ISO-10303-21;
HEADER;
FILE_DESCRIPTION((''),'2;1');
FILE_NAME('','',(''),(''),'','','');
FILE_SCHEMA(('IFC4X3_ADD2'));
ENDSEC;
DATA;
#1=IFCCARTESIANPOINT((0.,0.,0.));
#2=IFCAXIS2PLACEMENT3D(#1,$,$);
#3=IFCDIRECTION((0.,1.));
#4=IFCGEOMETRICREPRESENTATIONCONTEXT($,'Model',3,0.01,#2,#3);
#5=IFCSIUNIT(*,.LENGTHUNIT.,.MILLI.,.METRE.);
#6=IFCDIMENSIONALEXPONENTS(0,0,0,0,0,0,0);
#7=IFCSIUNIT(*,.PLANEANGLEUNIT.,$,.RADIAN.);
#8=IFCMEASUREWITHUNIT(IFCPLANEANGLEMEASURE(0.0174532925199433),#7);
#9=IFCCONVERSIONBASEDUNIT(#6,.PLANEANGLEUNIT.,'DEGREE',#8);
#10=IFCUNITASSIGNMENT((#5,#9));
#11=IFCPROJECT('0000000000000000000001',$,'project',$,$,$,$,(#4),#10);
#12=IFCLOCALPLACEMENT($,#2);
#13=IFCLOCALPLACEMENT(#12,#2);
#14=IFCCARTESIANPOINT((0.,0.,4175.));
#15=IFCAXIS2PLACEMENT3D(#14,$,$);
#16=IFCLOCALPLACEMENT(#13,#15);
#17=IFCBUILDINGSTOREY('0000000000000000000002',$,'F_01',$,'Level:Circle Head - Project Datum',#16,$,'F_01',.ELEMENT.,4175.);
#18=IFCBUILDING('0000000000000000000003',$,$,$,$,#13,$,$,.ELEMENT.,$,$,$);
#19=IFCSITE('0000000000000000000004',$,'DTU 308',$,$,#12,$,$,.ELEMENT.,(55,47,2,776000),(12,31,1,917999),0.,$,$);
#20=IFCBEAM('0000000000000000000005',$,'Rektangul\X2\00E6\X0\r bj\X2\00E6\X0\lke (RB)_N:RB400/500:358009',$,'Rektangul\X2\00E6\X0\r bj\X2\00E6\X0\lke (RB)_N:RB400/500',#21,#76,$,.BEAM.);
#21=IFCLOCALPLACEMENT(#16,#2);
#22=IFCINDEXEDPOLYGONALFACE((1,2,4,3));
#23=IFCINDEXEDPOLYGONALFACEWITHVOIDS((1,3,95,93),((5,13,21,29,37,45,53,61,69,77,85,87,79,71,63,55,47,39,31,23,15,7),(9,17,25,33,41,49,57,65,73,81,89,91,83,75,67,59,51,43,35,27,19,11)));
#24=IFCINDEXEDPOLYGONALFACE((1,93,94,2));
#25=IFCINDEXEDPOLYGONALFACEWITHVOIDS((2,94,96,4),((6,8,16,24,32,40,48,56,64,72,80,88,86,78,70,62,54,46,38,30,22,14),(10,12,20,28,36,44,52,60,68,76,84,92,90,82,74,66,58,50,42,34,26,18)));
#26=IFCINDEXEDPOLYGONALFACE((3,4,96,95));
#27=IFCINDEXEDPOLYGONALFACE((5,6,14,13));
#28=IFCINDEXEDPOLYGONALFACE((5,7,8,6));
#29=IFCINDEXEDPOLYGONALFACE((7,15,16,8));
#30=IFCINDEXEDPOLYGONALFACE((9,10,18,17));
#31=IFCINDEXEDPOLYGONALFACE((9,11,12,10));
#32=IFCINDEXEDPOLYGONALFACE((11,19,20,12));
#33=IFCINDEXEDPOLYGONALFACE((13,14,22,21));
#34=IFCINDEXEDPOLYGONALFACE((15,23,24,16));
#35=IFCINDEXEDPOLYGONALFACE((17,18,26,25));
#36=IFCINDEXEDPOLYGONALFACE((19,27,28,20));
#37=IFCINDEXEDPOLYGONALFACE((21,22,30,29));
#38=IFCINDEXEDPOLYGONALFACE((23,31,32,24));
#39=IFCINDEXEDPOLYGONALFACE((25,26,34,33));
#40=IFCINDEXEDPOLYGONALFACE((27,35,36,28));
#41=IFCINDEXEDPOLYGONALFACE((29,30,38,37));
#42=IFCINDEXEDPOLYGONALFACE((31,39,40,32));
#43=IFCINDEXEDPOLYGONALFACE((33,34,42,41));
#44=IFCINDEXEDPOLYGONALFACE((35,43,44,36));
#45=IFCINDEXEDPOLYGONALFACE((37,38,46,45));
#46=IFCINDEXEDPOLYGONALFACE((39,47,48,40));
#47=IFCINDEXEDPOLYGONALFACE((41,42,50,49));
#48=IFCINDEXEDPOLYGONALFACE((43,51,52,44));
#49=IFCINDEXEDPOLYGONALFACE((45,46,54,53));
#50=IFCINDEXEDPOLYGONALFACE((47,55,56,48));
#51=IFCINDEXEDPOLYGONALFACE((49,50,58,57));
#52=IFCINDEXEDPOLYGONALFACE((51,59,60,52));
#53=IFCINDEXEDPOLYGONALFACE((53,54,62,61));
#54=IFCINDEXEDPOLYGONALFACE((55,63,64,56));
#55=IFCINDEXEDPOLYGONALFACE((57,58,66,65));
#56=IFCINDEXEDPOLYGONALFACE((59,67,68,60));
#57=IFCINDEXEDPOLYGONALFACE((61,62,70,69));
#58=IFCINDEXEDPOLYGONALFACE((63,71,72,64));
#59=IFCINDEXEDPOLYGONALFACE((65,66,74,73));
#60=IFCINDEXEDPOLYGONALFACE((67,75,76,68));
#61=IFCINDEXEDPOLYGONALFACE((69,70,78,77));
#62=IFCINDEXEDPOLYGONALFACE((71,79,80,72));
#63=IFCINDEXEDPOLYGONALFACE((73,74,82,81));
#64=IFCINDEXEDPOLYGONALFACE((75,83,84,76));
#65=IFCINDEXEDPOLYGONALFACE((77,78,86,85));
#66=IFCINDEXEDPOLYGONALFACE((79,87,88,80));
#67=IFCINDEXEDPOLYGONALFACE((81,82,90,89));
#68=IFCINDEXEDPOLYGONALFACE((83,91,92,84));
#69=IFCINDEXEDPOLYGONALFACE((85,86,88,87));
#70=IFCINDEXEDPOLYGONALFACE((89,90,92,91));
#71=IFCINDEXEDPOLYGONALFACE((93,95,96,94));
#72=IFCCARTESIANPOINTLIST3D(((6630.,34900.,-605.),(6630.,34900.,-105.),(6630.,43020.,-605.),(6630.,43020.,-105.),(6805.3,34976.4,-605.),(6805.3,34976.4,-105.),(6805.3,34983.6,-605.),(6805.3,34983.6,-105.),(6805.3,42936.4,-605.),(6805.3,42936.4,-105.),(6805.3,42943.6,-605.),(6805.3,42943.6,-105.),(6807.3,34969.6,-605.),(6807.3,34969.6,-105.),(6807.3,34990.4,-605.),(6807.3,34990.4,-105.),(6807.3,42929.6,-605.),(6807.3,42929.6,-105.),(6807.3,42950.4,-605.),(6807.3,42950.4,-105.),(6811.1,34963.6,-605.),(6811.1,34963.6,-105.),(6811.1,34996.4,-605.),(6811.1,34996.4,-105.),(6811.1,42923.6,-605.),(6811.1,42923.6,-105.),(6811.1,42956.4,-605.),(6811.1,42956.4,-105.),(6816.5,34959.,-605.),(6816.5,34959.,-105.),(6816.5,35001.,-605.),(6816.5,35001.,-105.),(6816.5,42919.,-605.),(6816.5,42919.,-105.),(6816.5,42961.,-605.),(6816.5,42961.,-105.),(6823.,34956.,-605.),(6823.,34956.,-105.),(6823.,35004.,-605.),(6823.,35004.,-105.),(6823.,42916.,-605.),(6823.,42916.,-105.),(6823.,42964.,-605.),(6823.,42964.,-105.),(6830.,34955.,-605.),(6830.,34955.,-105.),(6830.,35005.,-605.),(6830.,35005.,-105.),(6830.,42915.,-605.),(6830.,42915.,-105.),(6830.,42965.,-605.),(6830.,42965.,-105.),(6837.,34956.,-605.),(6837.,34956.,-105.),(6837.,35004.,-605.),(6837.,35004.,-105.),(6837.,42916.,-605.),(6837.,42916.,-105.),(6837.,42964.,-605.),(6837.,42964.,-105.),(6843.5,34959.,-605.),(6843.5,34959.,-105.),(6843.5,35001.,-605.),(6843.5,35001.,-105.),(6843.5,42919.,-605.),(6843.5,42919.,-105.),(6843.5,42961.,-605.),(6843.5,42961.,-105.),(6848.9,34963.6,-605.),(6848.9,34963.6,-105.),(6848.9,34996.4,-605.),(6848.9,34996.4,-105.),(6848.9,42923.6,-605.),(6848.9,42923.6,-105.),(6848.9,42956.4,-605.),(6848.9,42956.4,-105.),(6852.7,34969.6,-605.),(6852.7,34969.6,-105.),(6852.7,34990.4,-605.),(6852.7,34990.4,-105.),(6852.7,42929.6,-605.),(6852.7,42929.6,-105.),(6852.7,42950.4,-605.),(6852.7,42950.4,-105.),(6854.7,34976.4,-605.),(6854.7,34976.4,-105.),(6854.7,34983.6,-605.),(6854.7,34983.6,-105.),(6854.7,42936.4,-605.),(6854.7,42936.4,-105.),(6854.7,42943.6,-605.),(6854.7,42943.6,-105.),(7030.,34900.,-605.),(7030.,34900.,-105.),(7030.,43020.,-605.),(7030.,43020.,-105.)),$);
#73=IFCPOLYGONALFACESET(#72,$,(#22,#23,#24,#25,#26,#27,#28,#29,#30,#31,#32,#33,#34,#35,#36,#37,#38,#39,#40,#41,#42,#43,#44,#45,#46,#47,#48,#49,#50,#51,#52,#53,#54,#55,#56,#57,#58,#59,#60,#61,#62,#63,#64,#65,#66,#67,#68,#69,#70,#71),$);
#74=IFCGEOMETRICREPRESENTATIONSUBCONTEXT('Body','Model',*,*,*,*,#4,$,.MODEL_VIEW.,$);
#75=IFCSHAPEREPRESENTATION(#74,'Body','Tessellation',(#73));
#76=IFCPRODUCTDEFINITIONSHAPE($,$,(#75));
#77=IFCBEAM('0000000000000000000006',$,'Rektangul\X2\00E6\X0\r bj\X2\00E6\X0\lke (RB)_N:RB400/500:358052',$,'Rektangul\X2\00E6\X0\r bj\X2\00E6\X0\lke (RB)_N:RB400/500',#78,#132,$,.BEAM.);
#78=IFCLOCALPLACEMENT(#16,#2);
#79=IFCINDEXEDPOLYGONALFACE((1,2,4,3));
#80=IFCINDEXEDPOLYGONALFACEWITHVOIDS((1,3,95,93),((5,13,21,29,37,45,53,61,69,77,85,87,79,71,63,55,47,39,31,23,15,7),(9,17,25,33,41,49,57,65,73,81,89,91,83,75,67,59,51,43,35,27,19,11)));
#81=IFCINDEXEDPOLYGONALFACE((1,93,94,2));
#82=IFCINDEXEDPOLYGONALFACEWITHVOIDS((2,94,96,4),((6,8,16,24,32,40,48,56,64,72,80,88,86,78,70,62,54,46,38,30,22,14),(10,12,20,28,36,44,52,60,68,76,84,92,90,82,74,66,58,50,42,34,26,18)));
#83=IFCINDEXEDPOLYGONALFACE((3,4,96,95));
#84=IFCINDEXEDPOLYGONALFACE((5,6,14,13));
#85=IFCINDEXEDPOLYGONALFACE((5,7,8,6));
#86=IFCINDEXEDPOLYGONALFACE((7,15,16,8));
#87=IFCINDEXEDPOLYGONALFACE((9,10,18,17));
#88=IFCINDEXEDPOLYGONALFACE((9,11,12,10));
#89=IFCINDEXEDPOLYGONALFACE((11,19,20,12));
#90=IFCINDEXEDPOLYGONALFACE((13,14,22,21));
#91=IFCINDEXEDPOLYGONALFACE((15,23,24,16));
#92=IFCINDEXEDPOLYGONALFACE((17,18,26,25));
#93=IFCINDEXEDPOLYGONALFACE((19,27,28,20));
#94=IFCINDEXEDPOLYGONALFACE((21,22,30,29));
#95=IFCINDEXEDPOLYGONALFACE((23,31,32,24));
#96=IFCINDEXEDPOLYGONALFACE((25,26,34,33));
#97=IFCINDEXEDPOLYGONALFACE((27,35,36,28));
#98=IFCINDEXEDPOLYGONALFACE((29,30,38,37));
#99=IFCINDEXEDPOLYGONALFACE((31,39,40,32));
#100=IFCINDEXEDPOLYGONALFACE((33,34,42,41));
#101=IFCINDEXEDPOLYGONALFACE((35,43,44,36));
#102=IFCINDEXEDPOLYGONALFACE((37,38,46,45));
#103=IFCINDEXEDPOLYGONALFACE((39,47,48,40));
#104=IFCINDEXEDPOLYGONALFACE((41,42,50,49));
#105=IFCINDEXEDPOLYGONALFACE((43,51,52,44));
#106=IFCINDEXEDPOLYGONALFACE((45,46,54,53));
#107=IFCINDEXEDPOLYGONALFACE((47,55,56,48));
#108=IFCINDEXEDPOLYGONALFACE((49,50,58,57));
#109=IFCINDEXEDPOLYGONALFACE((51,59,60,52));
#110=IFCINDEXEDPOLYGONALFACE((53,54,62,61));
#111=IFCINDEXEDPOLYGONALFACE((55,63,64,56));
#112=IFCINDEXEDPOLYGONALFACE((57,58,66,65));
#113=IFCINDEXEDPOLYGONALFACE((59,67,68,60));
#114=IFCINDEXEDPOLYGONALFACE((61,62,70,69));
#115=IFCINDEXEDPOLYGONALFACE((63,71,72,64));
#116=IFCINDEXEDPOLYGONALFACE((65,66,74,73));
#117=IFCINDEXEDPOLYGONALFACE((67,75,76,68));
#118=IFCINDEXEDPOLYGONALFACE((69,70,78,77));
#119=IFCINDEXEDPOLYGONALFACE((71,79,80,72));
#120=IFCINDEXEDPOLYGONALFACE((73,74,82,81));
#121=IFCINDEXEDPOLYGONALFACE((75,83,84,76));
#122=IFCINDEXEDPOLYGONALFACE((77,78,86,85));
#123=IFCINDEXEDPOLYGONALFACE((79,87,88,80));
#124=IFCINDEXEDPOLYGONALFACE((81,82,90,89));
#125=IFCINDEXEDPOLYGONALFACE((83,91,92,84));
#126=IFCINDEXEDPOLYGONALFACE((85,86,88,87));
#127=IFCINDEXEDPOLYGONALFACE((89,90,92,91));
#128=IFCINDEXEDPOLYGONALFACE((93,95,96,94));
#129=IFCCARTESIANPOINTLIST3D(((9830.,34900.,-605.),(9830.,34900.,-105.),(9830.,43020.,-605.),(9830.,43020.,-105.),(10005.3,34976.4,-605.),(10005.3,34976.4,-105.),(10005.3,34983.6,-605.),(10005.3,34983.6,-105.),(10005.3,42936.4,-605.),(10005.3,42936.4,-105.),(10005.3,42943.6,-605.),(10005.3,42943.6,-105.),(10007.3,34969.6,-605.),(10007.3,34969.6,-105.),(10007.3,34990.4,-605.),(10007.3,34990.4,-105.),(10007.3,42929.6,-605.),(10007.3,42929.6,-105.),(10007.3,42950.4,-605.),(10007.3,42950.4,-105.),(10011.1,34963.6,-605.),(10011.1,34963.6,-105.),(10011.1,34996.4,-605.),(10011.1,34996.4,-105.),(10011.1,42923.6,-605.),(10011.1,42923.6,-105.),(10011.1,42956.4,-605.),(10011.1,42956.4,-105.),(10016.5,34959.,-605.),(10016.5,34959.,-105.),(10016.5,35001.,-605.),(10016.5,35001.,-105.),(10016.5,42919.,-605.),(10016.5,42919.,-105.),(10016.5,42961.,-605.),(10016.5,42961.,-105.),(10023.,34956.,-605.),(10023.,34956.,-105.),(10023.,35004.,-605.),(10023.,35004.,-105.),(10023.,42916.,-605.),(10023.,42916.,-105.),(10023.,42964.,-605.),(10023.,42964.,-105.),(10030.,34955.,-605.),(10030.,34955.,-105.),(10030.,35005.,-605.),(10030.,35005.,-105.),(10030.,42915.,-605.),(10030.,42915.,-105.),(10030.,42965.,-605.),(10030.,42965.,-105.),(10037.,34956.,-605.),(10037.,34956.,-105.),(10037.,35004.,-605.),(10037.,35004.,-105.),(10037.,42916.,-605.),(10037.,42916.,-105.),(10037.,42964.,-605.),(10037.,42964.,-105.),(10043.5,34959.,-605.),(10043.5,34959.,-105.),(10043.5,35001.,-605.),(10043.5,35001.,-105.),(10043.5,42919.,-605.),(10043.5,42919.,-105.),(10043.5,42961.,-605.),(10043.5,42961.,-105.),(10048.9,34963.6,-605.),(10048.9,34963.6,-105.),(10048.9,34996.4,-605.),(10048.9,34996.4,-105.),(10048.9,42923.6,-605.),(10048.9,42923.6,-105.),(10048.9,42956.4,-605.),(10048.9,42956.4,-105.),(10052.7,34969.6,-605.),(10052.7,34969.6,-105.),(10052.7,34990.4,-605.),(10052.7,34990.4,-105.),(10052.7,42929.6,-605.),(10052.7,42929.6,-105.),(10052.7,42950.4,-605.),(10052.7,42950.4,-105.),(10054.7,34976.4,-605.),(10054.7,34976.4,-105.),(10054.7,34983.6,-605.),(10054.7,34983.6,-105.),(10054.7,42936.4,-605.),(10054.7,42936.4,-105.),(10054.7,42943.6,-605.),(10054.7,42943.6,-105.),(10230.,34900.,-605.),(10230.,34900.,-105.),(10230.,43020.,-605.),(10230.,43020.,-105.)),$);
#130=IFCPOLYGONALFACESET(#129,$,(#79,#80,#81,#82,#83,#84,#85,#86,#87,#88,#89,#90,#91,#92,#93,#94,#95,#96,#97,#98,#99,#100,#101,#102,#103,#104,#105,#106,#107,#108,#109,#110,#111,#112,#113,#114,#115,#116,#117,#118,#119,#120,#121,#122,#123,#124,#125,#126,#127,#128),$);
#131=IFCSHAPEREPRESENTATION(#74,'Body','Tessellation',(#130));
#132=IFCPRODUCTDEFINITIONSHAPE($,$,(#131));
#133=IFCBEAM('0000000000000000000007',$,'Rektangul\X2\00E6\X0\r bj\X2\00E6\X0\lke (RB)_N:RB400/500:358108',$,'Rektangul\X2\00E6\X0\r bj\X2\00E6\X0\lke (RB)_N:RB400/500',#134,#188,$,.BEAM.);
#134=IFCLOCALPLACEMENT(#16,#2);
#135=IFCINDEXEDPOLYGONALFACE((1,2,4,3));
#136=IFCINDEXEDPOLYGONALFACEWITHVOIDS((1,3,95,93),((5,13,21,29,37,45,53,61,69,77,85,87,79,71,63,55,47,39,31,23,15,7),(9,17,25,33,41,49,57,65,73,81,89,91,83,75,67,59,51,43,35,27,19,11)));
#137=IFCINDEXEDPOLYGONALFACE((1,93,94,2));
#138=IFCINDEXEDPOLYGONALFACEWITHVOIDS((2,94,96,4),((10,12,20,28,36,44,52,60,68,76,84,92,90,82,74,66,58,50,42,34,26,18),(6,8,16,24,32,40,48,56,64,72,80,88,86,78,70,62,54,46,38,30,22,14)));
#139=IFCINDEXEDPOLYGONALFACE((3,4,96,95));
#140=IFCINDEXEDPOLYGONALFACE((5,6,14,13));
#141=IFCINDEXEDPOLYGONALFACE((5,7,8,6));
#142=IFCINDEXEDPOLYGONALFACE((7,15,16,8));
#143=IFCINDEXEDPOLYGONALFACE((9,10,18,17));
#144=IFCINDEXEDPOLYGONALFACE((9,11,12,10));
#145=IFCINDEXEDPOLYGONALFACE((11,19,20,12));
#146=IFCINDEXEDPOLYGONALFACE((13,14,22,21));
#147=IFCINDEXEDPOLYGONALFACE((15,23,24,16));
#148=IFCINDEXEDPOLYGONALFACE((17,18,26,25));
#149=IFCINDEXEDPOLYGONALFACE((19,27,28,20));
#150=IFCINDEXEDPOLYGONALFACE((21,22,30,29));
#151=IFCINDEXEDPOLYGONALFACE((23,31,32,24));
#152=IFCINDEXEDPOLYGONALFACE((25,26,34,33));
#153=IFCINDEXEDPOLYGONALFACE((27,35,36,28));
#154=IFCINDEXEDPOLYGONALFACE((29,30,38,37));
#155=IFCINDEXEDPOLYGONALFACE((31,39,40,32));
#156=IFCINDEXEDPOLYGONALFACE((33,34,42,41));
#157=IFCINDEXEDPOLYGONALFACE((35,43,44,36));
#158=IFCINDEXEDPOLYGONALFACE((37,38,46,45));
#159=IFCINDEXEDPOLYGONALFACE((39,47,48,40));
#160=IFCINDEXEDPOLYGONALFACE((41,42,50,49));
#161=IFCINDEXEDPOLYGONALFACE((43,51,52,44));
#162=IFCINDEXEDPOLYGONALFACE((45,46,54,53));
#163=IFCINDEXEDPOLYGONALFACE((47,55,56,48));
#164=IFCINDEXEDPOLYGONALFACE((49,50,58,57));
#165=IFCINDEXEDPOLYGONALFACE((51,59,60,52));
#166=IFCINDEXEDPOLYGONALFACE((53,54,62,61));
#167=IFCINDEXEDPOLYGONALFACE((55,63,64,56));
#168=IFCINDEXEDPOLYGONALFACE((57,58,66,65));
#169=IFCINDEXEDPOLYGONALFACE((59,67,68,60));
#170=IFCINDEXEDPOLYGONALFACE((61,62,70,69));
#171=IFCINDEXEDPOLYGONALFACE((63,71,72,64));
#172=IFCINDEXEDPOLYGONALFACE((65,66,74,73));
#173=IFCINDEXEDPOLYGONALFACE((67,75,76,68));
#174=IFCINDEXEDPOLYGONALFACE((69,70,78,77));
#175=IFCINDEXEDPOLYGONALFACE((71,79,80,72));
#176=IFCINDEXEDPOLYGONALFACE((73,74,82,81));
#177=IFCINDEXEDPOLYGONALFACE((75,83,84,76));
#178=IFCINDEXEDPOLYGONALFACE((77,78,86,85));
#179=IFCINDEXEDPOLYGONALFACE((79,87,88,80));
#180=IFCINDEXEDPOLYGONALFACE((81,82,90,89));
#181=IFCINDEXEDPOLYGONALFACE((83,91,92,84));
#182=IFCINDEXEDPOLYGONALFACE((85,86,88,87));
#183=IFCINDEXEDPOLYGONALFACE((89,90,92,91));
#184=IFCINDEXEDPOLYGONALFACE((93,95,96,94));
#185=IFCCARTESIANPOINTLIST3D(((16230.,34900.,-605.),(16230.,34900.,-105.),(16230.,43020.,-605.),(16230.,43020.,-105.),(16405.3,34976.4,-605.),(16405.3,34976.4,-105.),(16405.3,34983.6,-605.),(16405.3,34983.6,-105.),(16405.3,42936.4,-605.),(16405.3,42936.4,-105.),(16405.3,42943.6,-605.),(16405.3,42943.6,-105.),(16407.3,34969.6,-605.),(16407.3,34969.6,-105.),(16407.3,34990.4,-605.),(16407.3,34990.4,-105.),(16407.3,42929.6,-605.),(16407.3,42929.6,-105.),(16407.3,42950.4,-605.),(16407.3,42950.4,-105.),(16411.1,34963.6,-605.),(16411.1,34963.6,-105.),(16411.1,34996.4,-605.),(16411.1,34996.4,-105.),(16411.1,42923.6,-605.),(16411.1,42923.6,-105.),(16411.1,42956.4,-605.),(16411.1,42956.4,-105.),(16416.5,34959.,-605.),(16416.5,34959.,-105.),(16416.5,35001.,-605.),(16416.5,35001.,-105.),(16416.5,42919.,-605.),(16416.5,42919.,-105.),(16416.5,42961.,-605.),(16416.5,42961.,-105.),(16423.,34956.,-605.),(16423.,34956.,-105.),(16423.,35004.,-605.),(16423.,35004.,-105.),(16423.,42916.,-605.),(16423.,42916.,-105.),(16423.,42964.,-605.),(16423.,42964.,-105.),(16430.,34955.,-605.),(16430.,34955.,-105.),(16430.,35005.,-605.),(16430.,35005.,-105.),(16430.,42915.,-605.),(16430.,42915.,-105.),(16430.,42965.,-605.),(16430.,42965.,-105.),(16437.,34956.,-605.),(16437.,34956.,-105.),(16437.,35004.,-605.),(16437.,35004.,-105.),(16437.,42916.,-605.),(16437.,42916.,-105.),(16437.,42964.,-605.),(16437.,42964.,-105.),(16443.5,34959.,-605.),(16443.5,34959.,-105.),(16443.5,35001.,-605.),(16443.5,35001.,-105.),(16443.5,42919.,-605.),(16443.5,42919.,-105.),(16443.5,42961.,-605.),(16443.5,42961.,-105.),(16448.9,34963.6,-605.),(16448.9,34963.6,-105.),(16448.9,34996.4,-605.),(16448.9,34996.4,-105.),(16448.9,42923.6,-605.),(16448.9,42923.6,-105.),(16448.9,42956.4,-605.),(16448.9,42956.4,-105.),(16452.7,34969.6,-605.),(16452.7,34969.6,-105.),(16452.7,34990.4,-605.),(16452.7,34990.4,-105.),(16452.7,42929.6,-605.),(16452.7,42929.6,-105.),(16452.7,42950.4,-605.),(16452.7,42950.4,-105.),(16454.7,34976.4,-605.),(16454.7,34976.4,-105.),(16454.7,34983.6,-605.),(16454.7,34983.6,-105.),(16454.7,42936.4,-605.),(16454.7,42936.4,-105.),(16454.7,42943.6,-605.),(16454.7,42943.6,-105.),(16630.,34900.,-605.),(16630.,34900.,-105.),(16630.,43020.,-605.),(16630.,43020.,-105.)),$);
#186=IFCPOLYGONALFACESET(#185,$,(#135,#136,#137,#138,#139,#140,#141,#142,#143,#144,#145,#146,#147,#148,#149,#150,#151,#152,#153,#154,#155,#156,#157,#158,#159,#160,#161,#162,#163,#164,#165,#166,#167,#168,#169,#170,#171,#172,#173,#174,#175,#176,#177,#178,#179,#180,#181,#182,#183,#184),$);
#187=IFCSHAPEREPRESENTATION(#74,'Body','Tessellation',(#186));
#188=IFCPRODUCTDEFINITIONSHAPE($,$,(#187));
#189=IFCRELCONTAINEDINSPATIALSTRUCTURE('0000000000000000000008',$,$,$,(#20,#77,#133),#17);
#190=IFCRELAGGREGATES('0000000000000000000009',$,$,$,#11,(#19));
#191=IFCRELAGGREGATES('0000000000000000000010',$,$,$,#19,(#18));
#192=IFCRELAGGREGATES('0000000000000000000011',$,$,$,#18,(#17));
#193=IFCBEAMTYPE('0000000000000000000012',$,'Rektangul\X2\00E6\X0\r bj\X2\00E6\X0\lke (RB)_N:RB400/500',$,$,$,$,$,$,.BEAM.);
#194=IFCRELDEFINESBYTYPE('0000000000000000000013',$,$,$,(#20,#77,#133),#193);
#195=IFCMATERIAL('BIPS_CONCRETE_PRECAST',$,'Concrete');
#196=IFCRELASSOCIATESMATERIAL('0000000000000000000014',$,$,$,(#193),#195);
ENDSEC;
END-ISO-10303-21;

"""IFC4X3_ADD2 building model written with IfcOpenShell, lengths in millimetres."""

from ifc_helpers import new_model, entity, si_unit, converted_unit, direction, frame, frame_2d, origin, place, context, subcontext, project, spatial, polyline, circle_curve, parameter, trimmed, segment, composite_curve, outline, extrude, source, transform, mapped, material, material_profile, profile_set, type_object, element, save


model = new_model("IFC4X3_ADD2")

# Units and contexts
model_context = context("Model", 3, precision=0.01, world=origin(), true_north=direction((0.0, 1.0)))
body_context = subcontext(model_context, "Body", "Model", "MODEL_VIEW")
ifc_project = project(units=[si_unit("LENGTHUNIT", "METRE", prefix="MILLI"), converted_unit("PLANEANGLEUNIT", "DEGREE", entity("IfcPlaneAngleMeasure", 0.0174532925199433), si_unit("PLANEANGLEUNIT", "RADIAN"), dimensions=[0, 0, 0, 0, 0, 0, 0])], contexts=[model_context])

# Site, building, storey
site_placement = place(None, origin())
site = spatial("IfcSite", under=ifc_project, at=site_placement, Name="DTU 308", CompositionType="ELEMENT", RefLatitude=(55, 47, 2, 776000), RefLongitude=(12, 31, 1, 917999), RefElevation=0.0)
building_placement = place(site_placement, origin())
building = spatial("IfcBuilding", under=site, at=building_placement, CompositionType="ELEMENT")
storey_placement = place(building_placement, frame((0.0, 0.0, 4175.0)))
storey = spatial("IfcBuildingStorey", under=building, at=storey_placement, Name="F_01", ObjectType="Level:Circle Head - Project Datum", LongName="F_01", CompositionType="ELEMENT", Elevation=4175.0)

# Beams
ifc_material_1 = material(Name="BIPS_CONCRETE_PRECAST", Category="Concrete")
ifc_material_profile_1 = material_profile(ifc_material_1, outline(polyline([(-4060.0, -200.0), (4060.0, -200.0), (4060.0, 200.0), (-4060.0, 200.0), (-4060.0, -200.0)]), holes=[composite_curve([segment(trimmed(circle_curve(frame_2d((3980.0, 0.0), x_axis=(-1.0, 0.0)), 25.0), [parameter(0.0)], [parameter(180.0)], True, "PARAMETER"), False, "CONTINUOUS"), segment(trimmed(circle_curve(frame_2d((3980.0, 0.0), x_axis=(-1.0, 0.0)), 25.0), [parameter(180.0)], [parameter(360.0)], True, "PARAMETER"), False, "CONTINUOUS")], self_intersect=False), composite_curve([segment(trimmed(circle_curve(frame_2d((-3980.0, 0.0), x_axis=(-1.0, 0.0)), 25.0), [parameter(0.0)], [parameter(180.0)], True, "PARAMETER"), False, "CONTINUOUS"), segment(trimmed(circle_curve(frame_2d((-3980.0, 0.0), x_axis=(-1.0, 0.0)), 25.0), [parameter(180.0)], [parameter(360.0)], True, "PARAMETER"), False, "CONTINUOUS")], self_intersect=False)]), Name="RB400/500")
ifc_profile_set_1 = profile_set([ifc_material_profile_1], Name="RB400/500")
beam_type_1 = type_object("IfcBeamType", Name="Rektangulær bjælke (RB)_N:RB400/500", PredefinedType="BEAM", material=ifc_profile_set_1)
shared_shape_1 = source(origin(), body_context, "Body", "SweptSolid", [
    extrude(outline(polyline([(-4060.0, -200.0), (4060.0, -200.0), (4060.0, 200.0), (-4060.0, 200.0), (-4060.0, -200.0)]), holes=[composite_curve([segment(trimmed(circle_curve(frame_2d((3980.0, 0.0), x_axis=(-1.0, 0.0)), 25.0), [parameter(0.0)], [parameter(180.0)], True, "PARAMETER"), False, "CONTINUOUS"), segment(trimmed(circle_curve(frame_2d((3980.0, 0.0), x_axis=(-1.0, 0.0)), 25.0), [parameter(180.0)], [parameter(360.0)], True, "PARAMETER"), False, "CONTINUOUS")], self_intersect=False), composite_curve([segment(trimmed(circle_curve(frame_2d((-3980.0, 0.0), x_axis=(-1.0, 0.0)), 25.0), [parameter(0.0)], [parameter(180.0)], True, "PARAMETER"), False, "CONTINUOUS"), segment(trimmed(circle_curve(frame_2d((-3980.0, 0.0), x_axis=(-1.0, 0.0)), 25.0), [parameter(180.0)], [parameter(360.0)], True, "PARAMETER"), False, "CONTINUOUS")], self_intersect=False)]), frame((0.0, 0.0, -250.0), z_axis=(0.0, 0.0, 1.0), x_axis=(-1.0, 0.0, 0.0)), (0.0, 0.0, 1.0), 500.0),
])
for number, where, z_axis, x_axis, name in (
    (1, (6830.0, 38960.0, -355.0), (0.0, 0.0, 1.0), (0.0, 1.0, 0.0), "Rektangulær bjælke (RB)_N:RB400/500:358009"),
    (2, (10030.0, 38960.0, -355.0), (0.0, 0.0, 1.0), (0.0, -1.0, 0.0), "Rektangulær bjælke (RB)_N:RB400/500:358052"),
    (3, (16430.0, 38960.0, -355.0), (0.0, 0.0, 1.0), (0.0, -1.0, 0.0), "Rektangulær bjælke (RB)_N:RB400/500:358108"),
):
    element("IfcBeam", number, at=place(storey_placement, frame(where, z_axis=z_axis, x_axis=x_axis)), inside=storey, type_object=beam_type_1, Name=name, ObjectType="Rektangulær bjælke (RB)_N:RB400/500", PredefinedType="BEAM", context=body_context, shape_type="MappedRepresentation", body=[
        mapped(shared_shape_1, transform((0.0, 0.0, 0.0), scale=1.0)),
    ])

save(model, "model.ifc")
